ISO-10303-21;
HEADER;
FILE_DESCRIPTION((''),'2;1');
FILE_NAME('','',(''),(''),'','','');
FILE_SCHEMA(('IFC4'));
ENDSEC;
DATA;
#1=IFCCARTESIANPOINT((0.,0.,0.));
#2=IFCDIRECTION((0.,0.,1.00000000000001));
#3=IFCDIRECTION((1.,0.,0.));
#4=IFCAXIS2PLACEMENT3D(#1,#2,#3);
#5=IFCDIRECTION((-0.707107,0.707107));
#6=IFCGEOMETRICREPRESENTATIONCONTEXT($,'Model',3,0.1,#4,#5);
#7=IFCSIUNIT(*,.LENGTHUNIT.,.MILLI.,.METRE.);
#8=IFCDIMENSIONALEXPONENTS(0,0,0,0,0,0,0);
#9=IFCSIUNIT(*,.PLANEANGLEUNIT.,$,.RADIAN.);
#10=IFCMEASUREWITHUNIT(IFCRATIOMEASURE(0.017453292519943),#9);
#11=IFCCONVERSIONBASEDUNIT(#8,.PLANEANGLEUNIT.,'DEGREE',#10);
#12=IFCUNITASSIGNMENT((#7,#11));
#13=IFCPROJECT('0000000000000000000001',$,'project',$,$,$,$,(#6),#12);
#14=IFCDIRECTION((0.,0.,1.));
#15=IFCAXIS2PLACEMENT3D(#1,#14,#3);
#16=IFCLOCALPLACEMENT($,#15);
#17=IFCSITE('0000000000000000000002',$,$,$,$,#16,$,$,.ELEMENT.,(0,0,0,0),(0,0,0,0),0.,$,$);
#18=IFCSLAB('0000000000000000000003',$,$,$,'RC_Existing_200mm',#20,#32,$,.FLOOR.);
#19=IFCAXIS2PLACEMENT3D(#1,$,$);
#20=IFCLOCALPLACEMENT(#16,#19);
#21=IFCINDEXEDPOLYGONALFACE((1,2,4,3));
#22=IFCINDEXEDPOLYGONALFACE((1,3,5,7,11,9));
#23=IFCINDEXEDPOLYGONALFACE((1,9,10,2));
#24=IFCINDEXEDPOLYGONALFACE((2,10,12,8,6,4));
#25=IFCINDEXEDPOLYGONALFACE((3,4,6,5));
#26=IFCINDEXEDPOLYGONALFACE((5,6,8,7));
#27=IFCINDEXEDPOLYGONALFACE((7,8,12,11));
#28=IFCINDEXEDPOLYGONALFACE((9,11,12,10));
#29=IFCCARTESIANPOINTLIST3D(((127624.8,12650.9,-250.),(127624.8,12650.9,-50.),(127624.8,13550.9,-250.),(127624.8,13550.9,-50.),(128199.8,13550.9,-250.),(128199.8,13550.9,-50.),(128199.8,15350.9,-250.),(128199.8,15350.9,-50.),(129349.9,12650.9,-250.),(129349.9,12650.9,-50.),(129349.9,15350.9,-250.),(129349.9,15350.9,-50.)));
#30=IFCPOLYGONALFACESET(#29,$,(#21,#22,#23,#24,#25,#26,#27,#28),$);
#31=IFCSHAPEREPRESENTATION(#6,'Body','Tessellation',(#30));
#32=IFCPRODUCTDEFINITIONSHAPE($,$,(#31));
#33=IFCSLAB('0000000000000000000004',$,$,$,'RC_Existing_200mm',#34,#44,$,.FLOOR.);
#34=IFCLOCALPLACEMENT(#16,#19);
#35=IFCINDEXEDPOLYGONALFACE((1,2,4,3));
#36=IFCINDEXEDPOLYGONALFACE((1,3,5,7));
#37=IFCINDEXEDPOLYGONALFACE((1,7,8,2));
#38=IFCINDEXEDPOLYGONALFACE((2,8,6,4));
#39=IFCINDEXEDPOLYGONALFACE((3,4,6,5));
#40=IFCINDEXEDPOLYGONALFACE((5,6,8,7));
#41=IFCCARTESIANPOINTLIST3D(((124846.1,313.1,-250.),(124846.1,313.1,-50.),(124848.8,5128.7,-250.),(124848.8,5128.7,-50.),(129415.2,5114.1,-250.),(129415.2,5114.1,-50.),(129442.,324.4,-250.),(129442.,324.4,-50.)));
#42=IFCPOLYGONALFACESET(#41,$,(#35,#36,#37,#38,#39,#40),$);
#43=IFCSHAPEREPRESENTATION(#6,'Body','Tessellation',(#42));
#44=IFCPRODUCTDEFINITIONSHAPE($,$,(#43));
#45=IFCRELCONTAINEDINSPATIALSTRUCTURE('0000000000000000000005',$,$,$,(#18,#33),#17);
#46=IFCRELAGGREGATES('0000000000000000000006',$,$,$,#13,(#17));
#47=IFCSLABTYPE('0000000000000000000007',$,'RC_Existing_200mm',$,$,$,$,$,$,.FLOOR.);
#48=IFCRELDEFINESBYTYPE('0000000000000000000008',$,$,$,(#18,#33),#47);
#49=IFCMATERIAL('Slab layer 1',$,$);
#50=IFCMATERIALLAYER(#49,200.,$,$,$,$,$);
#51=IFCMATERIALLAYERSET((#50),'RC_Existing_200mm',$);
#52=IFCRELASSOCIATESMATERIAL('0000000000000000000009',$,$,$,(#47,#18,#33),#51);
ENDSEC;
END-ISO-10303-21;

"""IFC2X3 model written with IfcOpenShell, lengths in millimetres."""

from ifc_helpers import new_model, entity, si_unit, converted_unit, direction, frame, origin_with_axes, place, context, project, spatial, polyline, outline, extrude, material, layer, layer_set, layer_usage, type_object, element, save


model = new_model("IFC2X3")

# Units and contexts
model_context = context("Model", 3, precision=0.1, world=frame((0.0, 0.0, 0.0), z_axis=(0.0, 0.0, 1.00000000000001), x_axis=(1.0, 0.0, 0.0)), true_north=direction((-0.707107, 0.707107)))
ifc_project = project(units=[si_unit("LENGTHUNIT", "METRE", prefix="MILLI"), converted_unit("PLANEANGLEUNIT", "DEGREE", entity("IfcRatioMeasure", 0.017453292519943), si_unit("PLANEANGLEUNIT", "RADIAN"), dimensions=[0, 0, 0, 0, 0, 0, 0])], contexts=[model_context])

# Site
site_placement = place(None, origin_with_axes())
site = spatial("IfcSite", under=ifc_project, at=site_placement, CompositionType="ELEMENT", RefLatitude=(0, 0, 0, 0), RefLongitude=(0, 0, 0, 0), RefElevation=0.0)

# Slabs
ifc_material = material(Name="Slab layer 1")
ifc_layer = layer(ifc_material, 200.0)
ifc_layer_set = layer_set([ifc_layer], Name="RC_Existing_200mm")
ifc_layer_usage = layer_usage(ifc_layer_set, "AXIS3", "POSITIVE", 0.0)
slab_type = type_object("IfcSlabType", Name="RC_Existing_200mm", PredefinedType="FLOOR", material=ifc_layer_set)
slab_1_placement = place(site_placement, frame((129349.9, 12650.9, -50.0), z_axis=(0.0, 0.0, 1.0), x_axis=(1.0, 0.0, 0.0)))
element("IfcSlab", 1, at=slab_1_placement, inside=site, type_object=slab_type, material=ifc_layer_usage, ObjectType="RC_Existing_200mm", PredefinedType="FLOOR", context=model_context, shape_type="SweptSolid", body=[
    extrude(outline(polyline([(0.0, 0.0), (-1725.1, 0.0), (-1725.1, 900.0), (-1150.1, 900.0), (-1150.1, 2700.0), (0.0, 2700.0), (0.0, 0.0)])), frame((0.0, 0.0, -200.0), z_axis=(0.0, 0.0, 1.0), x_axis=(1.0, 0.0, 0.0)), (0.0, 0.0, 1.0), 200.0),
])
slab_2_placement = place(site_placement, frame((124848.8, 5128.7, -50.0), z_axis=(0.0, 0.0, 1.0), x_axis=(-0.999995, 0.003214, 0.0)))
element("IfcSlab", 2, at=slab_2_placement, inside=site, type_object=slab_type, material=ifc_layer_usage, ObjectType="RC_Existing_200mm", PredefinedType="FLOOR", context=model_context, shape_type="SweptSolid", body=[
    extrude(outline(polyline([(0.0, 0.0), (-4566.4, 0.0), (-4608.6, 4789.6), (-12.7, 4815.6), (0.0, 0.0)])), frame((0.0, 0.0, -200.0), z_axis=(0.0, 0.0, 1.0), x_axis=(1.0, 0.0, 0.0)), (0.0, 0.0, 1.0), 200.0),
])

save(model, "model.ifc")
